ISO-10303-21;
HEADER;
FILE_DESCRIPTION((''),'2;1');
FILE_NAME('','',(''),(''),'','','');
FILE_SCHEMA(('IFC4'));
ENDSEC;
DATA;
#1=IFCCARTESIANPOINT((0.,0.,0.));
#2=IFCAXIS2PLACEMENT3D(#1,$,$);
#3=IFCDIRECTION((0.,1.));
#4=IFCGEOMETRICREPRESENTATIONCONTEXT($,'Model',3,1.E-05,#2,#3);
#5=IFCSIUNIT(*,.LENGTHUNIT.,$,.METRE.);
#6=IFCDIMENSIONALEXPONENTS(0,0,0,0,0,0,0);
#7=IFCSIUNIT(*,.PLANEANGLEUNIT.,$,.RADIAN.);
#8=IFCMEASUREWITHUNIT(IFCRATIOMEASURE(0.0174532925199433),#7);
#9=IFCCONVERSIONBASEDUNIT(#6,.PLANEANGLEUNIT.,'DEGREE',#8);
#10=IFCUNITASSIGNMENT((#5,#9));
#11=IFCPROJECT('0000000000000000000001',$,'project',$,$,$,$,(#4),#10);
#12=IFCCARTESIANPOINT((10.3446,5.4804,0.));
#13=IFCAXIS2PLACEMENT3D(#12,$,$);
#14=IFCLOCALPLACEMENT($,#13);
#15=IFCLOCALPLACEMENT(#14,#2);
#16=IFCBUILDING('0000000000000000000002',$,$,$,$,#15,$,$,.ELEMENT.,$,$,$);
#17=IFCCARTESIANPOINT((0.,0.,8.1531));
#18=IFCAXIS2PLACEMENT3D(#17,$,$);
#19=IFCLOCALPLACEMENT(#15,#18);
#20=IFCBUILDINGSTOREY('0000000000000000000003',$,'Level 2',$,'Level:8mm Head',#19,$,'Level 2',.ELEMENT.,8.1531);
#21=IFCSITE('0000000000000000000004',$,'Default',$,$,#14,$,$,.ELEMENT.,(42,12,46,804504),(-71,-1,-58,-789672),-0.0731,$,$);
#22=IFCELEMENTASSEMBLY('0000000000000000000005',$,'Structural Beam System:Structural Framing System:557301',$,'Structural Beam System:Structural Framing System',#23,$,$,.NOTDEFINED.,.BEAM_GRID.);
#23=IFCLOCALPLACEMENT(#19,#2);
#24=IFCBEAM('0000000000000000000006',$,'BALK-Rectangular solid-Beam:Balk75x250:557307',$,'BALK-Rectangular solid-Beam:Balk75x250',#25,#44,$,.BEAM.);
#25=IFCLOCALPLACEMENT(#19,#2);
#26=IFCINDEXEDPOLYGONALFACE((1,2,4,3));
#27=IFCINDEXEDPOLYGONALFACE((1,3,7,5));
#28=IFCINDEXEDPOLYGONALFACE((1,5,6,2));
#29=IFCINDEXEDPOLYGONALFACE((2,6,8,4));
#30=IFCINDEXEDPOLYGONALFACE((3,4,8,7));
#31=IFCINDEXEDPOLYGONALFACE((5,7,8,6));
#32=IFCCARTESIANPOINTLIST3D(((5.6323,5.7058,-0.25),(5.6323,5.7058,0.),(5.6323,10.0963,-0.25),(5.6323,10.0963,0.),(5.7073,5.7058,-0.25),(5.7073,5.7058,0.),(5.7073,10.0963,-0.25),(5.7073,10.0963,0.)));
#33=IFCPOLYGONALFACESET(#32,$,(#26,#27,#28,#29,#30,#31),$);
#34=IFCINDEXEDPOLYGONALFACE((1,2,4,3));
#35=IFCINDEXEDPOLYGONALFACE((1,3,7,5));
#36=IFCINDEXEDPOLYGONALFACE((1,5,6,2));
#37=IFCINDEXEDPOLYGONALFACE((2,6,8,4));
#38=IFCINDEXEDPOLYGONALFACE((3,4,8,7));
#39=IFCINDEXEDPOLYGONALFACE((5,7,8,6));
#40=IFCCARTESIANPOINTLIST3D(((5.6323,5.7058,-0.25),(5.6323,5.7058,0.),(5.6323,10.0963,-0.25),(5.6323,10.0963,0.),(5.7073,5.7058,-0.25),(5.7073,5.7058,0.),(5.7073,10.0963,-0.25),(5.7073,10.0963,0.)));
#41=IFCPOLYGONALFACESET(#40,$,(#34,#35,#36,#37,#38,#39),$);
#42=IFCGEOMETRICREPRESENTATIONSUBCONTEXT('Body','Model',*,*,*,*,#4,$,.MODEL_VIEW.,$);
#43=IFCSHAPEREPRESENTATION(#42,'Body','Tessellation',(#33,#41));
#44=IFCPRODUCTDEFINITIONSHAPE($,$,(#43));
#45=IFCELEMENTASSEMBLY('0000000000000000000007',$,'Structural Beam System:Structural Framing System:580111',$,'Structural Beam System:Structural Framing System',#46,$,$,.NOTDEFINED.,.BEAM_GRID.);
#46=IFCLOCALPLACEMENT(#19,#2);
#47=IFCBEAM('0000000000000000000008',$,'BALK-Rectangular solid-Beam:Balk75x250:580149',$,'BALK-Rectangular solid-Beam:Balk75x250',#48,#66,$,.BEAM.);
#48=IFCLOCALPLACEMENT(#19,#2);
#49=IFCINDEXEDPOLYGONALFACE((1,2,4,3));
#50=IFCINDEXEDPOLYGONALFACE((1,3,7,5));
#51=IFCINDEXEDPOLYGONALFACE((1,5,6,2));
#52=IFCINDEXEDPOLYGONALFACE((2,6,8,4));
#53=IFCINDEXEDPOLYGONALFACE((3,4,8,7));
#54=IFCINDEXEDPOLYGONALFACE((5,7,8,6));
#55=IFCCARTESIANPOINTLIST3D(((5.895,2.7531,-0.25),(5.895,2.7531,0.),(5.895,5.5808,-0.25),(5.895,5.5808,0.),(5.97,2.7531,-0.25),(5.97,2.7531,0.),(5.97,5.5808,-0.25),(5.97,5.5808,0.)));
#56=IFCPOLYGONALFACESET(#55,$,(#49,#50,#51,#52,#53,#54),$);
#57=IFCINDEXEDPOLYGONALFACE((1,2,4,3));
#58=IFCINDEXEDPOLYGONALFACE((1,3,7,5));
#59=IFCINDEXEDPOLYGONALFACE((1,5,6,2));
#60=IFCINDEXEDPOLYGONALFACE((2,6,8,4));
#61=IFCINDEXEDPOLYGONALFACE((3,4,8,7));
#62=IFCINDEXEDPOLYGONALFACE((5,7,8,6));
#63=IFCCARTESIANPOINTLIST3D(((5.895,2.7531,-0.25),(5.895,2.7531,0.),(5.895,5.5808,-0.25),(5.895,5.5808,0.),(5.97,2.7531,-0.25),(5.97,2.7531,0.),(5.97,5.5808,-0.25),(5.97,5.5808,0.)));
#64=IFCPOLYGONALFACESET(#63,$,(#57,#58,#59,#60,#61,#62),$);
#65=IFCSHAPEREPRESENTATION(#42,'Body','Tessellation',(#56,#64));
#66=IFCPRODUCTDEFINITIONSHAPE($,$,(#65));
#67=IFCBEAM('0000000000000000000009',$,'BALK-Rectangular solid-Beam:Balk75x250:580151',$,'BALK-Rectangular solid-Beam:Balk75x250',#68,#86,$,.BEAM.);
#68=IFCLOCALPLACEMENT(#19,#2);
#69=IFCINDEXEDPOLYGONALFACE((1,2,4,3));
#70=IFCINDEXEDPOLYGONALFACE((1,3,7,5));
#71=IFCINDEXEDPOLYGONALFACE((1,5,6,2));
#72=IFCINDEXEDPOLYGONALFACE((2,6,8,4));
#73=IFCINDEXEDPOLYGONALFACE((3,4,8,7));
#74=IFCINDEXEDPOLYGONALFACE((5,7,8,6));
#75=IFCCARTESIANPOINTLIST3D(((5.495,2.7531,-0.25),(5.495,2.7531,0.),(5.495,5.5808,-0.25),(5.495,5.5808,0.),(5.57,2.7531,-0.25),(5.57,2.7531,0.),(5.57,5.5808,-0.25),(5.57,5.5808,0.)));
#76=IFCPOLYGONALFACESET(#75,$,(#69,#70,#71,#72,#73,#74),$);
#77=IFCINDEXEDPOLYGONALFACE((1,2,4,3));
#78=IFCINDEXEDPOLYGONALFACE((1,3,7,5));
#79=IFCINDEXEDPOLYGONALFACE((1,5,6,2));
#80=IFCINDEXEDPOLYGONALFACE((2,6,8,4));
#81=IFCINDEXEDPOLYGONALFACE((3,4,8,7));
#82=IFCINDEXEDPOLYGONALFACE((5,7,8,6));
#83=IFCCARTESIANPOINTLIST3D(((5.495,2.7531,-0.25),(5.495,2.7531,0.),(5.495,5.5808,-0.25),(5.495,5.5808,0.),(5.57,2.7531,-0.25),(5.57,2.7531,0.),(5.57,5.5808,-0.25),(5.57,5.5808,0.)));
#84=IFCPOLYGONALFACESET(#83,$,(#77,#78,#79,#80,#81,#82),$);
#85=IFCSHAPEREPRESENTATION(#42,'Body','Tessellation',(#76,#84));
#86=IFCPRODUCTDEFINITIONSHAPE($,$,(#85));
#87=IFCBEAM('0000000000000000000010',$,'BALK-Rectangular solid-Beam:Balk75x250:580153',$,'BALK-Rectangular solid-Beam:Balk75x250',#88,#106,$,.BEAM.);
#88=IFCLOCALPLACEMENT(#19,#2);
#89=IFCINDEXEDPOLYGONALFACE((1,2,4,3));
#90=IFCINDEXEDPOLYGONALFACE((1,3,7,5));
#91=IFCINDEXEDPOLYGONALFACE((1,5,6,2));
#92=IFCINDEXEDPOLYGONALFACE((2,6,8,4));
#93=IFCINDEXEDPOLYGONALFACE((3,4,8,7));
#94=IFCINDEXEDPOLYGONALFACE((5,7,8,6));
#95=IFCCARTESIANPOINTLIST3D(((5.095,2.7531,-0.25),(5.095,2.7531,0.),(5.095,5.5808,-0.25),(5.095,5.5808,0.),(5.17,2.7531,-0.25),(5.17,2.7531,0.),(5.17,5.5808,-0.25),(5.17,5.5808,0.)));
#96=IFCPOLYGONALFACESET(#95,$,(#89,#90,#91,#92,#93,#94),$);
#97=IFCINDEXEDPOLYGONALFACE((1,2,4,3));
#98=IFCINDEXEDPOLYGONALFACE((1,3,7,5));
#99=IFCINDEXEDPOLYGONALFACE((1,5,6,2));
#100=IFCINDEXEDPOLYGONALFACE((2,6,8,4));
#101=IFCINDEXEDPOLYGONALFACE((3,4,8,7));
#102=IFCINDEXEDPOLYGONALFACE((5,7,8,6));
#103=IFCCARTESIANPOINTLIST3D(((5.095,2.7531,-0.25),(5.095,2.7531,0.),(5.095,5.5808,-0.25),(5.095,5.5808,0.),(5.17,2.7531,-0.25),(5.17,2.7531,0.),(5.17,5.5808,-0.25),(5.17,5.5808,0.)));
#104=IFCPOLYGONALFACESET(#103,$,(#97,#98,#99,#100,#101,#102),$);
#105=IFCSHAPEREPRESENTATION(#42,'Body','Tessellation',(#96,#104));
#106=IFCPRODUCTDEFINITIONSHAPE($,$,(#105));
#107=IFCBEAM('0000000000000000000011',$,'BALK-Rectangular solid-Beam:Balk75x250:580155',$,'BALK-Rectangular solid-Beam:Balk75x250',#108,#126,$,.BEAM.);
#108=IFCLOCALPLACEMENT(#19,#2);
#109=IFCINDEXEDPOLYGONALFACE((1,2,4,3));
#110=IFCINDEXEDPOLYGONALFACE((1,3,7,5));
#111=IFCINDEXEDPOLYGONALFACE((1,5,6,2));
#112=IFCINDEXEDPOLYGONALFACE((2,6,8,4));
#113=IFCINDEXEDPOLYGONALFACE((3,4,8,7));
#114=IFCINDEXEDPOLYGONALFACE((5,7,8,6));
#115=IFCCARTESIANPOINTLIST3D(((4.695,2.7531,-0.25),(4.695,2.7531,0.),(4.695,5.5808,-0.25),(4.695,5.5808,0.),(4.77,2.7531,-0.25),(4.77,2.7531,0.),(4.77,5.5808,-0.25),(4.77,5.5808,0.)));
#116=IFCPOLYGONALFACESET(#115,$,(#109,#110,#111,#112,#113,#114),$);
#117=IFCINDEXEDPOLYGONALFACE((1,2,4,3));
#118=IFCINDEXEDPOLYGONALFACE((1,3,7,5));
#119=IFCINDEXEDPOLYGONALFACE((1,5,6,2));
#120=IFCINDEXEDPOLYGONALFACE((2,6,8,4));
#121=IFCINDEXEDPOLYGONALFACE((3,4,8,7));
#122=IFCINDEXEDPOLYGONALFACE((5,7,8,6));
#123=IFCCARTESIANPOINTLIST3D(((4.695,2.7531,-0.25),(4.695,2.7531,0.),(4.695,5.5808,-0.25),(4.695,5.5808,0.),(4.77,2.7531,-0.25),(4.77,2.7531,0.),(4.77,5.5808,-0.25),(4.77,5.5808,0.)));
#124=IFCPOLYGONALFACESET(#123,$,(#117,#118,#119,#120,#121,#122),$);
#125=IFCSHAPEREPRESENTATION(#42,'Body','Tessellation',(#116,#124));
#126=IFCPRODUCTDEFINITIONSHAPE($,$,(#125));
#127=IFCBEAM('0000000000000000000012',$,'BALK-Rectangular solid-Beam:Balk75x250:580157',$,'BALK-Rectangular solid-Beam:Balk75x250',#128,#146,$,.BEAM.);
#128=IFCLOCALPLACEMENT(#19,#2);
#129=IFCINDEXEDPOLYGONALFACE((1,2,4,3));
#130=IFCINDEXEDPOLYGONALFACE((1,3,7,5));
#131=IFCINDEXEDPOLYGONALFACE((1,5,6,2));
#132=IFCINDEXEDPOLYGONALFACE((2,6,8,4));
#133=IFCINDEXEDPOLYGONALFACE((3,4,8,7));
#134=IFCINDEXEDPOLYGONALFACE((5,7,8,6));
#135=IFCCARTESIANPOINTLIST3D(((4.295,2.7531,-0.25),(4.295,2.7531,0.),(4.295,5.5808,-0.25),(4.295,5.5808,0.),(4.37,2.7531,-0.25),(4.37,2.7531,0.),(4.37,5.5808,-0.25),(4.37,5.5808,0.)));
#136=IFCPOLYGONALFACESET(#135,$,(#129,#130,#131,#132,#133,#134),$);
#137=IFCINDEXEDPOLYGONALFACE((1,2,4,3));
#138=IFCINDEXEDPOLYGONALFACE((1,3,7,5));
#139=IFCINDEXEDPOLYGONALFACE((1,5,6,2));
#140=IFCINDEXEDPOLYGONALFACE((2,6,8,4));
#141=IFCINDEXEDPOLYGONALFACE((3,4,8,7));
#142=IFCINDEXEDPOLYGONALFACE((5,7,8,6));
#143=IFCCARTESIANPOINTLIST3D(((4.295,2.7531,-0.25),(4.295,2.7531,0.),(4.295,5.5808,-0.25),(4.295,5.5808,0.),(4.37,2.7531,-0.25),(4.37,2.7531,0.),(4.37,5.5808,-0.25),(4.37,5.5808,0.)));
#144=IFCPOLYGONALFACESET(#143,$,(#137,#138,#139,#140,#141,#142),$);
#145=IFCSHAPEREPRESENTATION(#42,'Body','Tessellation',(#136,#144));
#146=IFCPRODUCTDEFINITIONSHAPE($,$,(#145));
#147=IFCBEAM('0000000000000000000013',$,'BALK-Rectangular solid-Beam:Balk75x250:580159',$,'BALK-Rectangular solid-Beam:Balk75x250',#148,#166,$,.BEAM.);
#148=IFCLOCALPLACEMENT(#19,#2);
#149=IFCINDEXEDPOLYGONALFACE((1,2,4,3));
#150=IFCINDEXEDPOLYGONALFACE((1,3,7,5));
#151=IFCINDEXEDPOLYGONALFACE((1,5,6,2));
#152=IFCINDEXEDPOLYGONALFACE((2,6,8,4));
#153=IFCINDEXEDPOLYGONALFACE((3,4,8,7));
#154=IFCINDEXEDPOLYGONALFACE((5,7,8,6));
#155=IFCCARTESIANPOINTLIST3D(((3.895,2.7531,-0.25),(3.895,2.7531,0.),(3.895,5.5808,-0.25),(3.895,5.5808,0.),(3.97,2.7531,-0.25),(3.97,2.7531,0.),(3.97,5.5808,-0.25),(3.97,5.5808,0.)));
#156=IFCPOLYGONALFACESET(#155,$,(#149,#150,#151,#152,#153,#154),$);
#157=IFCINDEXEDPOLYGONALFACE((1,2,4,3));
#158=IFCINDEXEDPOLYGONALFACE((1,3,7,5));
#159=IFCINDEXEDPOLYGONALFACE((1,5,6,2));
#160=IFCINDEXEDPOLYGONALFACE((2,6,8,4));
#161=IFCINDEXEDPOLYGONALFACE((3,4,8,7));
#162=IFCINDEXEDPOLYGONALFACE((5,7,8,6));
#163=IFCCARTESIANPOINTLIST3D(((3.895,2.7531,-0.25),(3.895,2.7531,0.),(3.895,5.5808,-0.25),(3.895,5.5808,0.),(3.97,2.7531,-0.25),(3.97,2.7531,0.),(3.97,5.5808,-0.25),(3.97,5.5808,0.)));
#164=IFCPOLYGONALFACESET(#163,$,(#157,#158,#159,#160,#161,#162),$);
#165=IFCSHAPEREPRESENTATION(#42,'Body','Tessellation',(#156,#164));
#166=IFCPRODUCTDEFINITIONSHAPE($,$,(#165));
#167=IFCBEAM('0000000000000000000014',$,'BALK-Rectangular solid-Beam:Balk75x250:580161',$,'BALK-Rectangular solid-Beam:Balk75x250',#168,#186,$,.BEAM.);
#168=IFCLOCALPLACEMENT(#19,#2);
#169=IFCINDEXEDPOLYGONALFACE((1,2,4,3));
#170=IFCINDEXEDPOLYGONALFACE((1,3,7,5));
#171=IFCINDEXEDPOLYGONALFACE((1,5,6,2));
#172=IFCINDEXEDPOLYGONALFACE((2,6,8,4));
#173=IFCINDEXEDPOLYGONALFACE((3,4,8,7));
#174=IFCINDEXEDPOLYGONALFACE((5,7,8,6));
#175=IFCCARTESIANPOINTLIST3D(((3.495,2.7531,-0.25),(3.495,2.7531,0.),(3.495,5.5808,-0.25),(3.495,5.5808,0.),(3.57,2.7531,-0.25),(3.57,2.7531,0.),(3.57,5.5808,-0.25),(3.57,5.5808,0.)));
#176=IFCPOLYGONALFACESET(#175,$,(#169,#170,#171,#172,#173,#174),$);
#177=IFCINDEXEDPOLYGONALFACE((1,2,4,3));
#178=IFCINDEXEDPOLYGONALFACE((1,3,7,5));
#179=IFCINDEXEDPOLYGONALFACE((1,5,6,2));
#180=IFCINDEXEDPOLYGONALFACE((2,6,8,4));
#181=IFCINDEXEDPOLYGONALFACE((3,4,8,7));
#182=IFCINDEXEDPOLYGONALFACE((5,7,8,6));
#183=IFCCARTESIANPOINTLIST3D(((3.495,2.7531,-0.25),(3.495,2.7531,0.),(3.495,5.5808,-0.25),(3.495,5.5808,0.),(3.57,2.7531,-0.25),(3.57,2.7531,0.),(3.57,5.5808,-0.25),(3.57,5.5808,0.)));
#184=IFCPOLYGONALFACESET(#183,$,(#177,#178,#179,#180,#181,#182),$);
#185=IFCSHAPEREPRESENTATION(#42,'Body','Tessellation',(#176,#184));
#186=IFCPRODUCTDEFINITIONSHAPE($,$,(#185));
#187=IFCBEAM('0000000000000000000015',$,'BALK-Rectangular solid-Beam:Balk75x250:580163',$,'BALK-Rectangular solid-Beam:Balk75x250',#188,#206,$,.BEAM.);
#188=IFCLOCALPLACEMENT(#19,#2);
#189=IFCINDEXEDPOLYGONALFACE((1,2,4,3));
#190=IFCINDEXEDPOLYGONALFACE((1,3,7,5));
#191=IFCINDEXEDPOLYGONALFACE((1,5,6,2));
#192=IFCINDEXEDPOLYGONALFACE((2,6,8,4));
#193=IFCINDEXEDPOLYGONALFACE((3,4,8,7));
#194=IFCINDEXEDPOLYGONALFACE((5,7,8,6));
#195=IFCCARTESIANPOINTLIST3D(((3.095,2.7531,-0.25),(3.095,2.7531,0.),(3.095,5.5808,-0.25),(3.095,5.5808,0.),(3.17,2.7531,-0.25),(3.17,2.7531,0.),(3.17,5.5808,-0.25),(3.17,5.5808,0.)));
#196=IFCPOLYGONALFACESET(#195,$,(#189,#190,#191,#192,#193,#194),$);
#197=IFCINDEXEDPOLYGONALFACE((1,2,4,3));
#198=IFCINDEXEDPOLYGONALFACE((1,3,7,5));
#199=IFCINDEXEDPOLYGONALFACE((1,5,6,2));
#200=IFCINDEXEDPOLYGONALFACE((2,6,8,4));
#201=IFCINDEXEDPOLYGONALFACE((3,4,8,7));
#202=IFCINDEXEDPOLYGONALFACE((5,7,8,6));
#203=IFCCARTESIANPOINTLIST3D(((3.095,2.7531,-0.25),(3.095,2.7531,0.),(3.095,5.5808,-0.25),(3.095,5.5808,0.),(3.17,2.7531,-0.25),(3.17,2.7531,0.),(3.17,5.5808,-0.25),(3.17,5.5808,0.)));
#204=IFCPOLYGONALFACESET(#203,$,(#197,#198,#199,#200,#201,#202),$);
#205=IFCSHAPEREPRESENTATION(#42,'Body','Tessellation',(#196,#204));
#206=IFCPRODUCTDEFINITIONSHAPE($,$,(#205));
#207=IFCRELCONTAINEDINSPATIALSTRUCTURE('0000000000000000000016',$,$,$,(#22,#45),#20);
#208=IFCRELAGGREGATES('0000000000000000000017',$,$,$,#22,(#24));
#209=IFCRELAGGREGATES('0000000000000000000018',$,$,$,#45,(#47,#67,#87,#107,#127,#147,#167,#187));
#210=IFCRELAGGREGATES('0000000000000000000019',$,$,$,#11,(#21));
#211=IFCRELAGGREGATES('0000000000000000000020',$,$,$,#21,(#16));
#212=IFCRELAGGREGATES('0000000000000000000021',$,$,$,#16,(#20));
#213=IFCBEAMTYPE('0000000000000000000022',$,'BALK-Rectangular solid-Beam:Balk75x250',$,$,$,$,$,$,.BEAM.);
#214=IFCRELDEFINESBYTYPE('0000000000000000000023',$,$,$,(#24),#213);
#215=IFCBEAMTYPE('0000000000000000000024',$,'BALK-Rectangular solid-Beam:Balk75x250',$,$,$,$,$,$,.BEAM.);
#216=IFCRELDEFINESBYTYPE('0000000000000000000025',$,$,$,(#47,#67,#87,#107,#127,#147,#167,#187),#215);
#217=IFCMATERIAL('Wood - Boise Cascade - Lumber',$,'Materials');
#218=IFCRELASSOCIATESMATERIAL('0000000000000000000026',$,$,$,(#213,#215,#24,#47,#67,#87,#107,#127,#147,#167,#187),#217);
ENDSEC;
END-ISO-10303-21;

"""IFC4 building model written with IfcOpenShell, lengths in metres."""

from ifc_helpers import new_model, entity, si_unit, converted_unit, direction, frame, frame_2d, origin, origin_2d_with_axis, place, context, subcontext, project, spatial, rectangle, extrude, source, transform, mapped, material, material_profile, profile_set, profile_usage, type_object, type_shapes, element, aggregate, save


model = new_model("IFC4")

# Units and contexts
model_context = context("Model", 3, precision=1e-05, world=origin(), true_north=direction((0.0, 1.0)))
body_context = subcontext(model_context, "Body", "Model", "MODEL_VIEW")
ifc_project = project(units=[si_unit("LENGTHUNIT", "METRE"), converted_unit("PLANEANGLEUNIT", "DEGREE", entity("IfcRatioMeasure", 0.0174532925199433), si_unit("PLANEANGLEUNIT", "RADIAN"), dimensions=[0, 0, 0, 0, 0, 0, 0])], contexts=[model_context])

# Site, building, storey
site_placement = place(None, frame((10.3446, 5.4804, 0.0)))
site = spatial("IfcSite", under=ifc_project, at=site_placement, Name="Default", CompositionType="ELEMENT", RefLatitude=(42, 12, 46, 804504), RefLongitude=(-71, -1, -58, -789672), RefElevation=-0.0731)
building_placement = place(site_placement, origin())
building = spatial("IfcBuilding", under=site, at=building_placement, CompositionType="ELEMENT")
storey_placement = place(building_placement, frame((0.0, 0.0, 8.1531)))
storey = spatial("IfcBuildingStorey", under=building, at=storey_placement, Name="Level 2", ObjectType="Level:8mm Head", LongName="Level 2", CompositionType="ELEMENT", Elevation=8.1531)

# Element assembly, beam
assembly_1_placement = place(storey_placement, origin())
assembly_1 = element("IfcElementAssembly", 1, at=assembly_1_placement, inside=storey, Name="Structural Beam System:Structural Framing System:557301", ObjectType="Structural Beam System:Structural Framing System", AssemblyPlace="NOTDEFINED", PredefinedType="BEAM_GRID")
ifc_material_1 = material(Name="Wood - Boise Cascade - Lumber", Category="Materials")
ifc_material_profile = material_profile(ifc_material_1, rectangle(XDim=0.25, YDim=0.075, at=frame_2d((0.0, 0.0), x_axis=(1.0, 0.0))), Name="Balk75x250")
ifc_profile_set = profile_set([ifc_material_profile], Name="Balk75x250")
ifc_profile_usage_1 = profile_usage(ifc_profile_set, cardinal=8)
beam_type_1 = type_object("IfcBeamType", Name="BALK-Rectangular solid-Beam:Balk75x250", PredefinedType="BEAM", material=ifc_profile_set)
shared_shape_1 = source(origin(), body_context, "Body", "SweptSolid", [
    extrude(rectangle(XDim=0.25, YDim=0.075, at=origin_2d_with_axis()), frame((-2.3015, 0.0, 0.0), z_axis=(1.0, 0.0, 0.0), x_axis=(0.0, 0.0, -1.0)), (0.0, 0.0, 1.0), 4.3905),
    extrude(rectangle(XDim=0.25, YDim=0.075, at=origin_2d_with_axis()), frame((-2.3015, 0.0, 0.0), z_axis=(1.0, 0.0, 0.0), x_axis=(0.0, 0.0, -1.0)), (0.0, 0.0, 1.0), 4.3905),
])
type_shapes(beam_type_1, [shared_shape_1])
beam_1_placement = place(assembly_1_placement, frame((5.6698, 8.0073, -0.125), z_axis=(0.0, 0.0, 1.0), x_axis=(0.0, 1.0, 0.0)))
beam_1 = element("IfcBeam", 2, at=beam_1_placement, type_object=beam_type_1, material=ifc_profile_usage_1, Name="BALK-Rectangular solid-Beam:Balk75x250:557307", ObjectType="BALK-Rectangular solid-Beam:Balk75x250", PredefinedType="BEAM", context=body_context, shape_type="MappedRepresentation", body=[
    mapped(shared_shape_1, transform((0.0, 0.0, 0.0), scale=1.0)),
])
aggregate(assembly_1, [beam_1])

# Element assembly, beams
assembly_2_placement = place(storey_placement, origin())
assembly_2 = element("IfcElementAssembly", 3, at=assembly_2_placement, inside=storey, Name="Structural Beam System:Structural Framing System:580111", ObjectType="Structural Beam System:Structural Framing System", AssemblyPlace="NOTDEFINED", PredefinedType="BEAM_GRID")
ifc_profile_usage_2 = profile_usage(ifc_profile_set, cardinal=8)
beam_type_2 = type_object("IfcBeamType", Name="BALK-Rectangular solid-Beam:Balk75x250", PredefinedType="BEAM", material=ifc_profile_set)
shared_shape_2 = source(origin(), body_context, "Body", "SweptSolid", [
    extrude(rectangle(XDim=0.25, YDim=0.075, at=origin_2d_with_axis()), frame((-1.4138, 0.0, 0.0), z_axis=(1.0, 0.0, 0.0), x_axis=(0.0, 0.0, -1.0)), (0.0, 0.0, 1.0), 2.8276),
    extrude(rectangle(XDim=0.25, YDim=0.075, at=origin_2d_with_axis()), frame((-1.4138, 0.0, 0.0), z_axis=(1.0, 0.0, 0.0), x_axis=(0.0, 0.0, -1.0)), (0.0, 0.0, 1.0), 2.8276),
])
type_shapes(beam_type_2, [shared_shape_2])
beam_2_placement = place(assembly_2_placement, frame((5.9325, 4.167, -0.125), z_axis=(0.0, 0.0, 1.0), x_axis=(0.0, -1.0, 0.0)))
beam_2 = element("IfcBeam", 4, at=beam_2_placement, type_object=beam_type_2, material=ifc_profile_usage_2, Name="BALK-Rectangular solid-Beam:Balk75x250:580149", ObjectType="BALK-Rectangular solid-Beam:Balk75x250", PredefinedType="BEAM", context=body_context, shape_type="MappedRepresentation", body=[
    mapped(shared_shape_2, transform((0.0, 0.0, 0.0), scale=1.0)),
])
ifc_profile_usage_3 = profile_usage(ifc_profile_set, cardinal=8)
beam_3_placement = place(assembly_2_placement, frame((5.5325, 4.167, -0.125), z_axis=(0.0, 0.0, 1.0), x_axis=(0.0, -1.0, 0.0)))
beam_3 = element("IfcBeam", 5, at=beam_3_placement, type_object=beam_type_2, material=ifc_profile_usage_3, Name="BALK-Rectangular solid-Beam:Balk75x250:580151", ObjectType="BALK-Rectangular solid-Beam:Balk75x250", PredefinedType="BEAM", context=body_context, shape_type="MappedRepresentation", body=[
    mapped(shared_shape_2, transform((0.0, 0.0, 0.0), scale=1.0)),
])
ifc_profile_usage_4 = profile_usage(ifc_profile_set, cardinal=8)
beam_4_placement = place(assembly_2_placement, frame((5.1325, 4.167, -0.125), z_axis=(0.0, 0.0, 1.0), x_axis=(0.0, -1.0, 0.0)))
beam_4 = element("IfcBeam", 6, at=beam_4_placement, type_object=beam_type_2, material=ifc_profile_usage_4, Name="BALK-Rectangular solid-Beam:Balk75x250:580153", ObjectType="BALK-Rectangular solid-Beam:Balk75x250", PredefinedType="BEAM", context=body_context, shape_type="MappedRepresentation", body=[
    mapped(shared_shape_2, transform((0.0, 0.0, 0.0), scale=1.0)),
])
ifc_profile_usage_5 = profile_usage(ifc_profile_set, cardinal=8)
beam_5_placement = place(assembly_2_placement, frame((4.7325, 4.167, -0.125), z_axis=(0.0, 0.0, 1.0), x_axis=(0.0, -1.0, 0.0)))
beam_5 = element("IfcBeam", 7, at=beam_5_placement, type_object=beam_type_2, material=ifc_profile_usage_5, Name="BALK-Rectangular solid-Beam:Balk75x250:580155", ObjectType="BALK-Rectangular solid-Beam:Balk75x250", PredefinedType="BEAM", context=body_context, shape_type="MappedRepresentation", body=[
    mapped(shared_shape_2, transform((0.0, 0.0, 0.0), scale=1.0)),
])
ifc_profile_usage_6 = profile_usage(ifc_profile_set, cardinal=8)
beam_6_placement = place(assembly_2_placement, frame((4.3325, 4.167, -0.125), z_axis=(0.0, 0.0, 1.0), x_axis=(0.0, -1.0, 0.0)))
beam_6 = element("IfcBeam", 8, at=beam_6_placement, type_object=beam_type_2, material=ifc_profile_usage_6, Name="BALK-Rectangular solid-Beam:Balk75x250:580157", ObjectType="BALK-Rectangular solid-Beam:Balk75x250", PredefinedType="BEAM", context=body_context, shape_type="MappedRepresentation", body=[
    mapped(shared_shape_2, transform((0.0, 0.0, 0.0), scale=1.0)),
])
ifc_profile_usage_7 = profile_usage(ifc_profile_set, cardinal=8)
beam_7_placement = place(assembly_2_placement, frame((3.9325, 4.167, -0.125), z_axis=(0.0, 0.0, 1.0), x_axis=(0.0, -1.0, 0.0)))
beam_7 = element("IfcBeam", 9, at=beam_7_placement, type_object=beam_type_2, material=ifc_profile_usage_7, Name="BALK-Rectangular solid-Beam:Balk75x250:580159", ObjectType="BALK-Rectangular solid-Beam:Balk75x250", PredefinedType="BEAM", context=body_context, shape_type="MappedRepresentation", body=[
    mapped(shared_shape_2, transform((0.0, 0.0, 0.0), scale=1.0)),
])
ifc_profile_usage_8 = profile_usage(ifc_profile_set, cardinal=8)
beam_8_placement = place(assembly_2_placement, frame((3.5325, 4.167, -0.125), z_axis=(0.0, 0.0, 1.0), x_axis=(0.0, -1.0, 0.0)))
beam_8 = element("IfcBeam", 10, at=beam_8_placement, type_object=beam_type_2, material=ifc_profile_usage_8, Name="BALK-Rectangular solid-Beam:Balk75x250:580161", ObjectType="BALK-Rectangular solid-Beam:Balk75x250", PredefinedType="BEAM", context=body_context, shape_type="MappedRepresentation", body=[
    mapped(shared_shape_2, transform((0.0, 0.0, 0.0), scale=1.0)),
])
ifc_profile_usage_9 = profile_usage(ifc_profile_set, cardinal=8)
beam_9_placement = place(assembly_2_placement, frame((3.1325, 4.167, -0.125), z_axis=(0.0, 0.0, 1.0), x_axis=(0.0, -1.0, 0.0)))
beam_9 = element("IfcBeam", 11, at=beam_9_placement, type_object=beam_type_2, material=ifc_profile_usage_9, Name="BALK-Rectangular solid-Beam:Balk75x250:580163", ObjectType="BALK-Rectangular solid-Beam:Balk75x250", PredefinedType="BEAM", context=body_context, shape_type="MappedRepresentation", body=[
    mapped(shared_shape_2, transform((0.0, 0.0, 0.0), scale=1.0)),
])
aggregate(assembly_2, [beam_2, beam_3, beam_4, beam_5, beam_6, beam_7, beam_8, beam_9])

save(model, "model.ifc")
